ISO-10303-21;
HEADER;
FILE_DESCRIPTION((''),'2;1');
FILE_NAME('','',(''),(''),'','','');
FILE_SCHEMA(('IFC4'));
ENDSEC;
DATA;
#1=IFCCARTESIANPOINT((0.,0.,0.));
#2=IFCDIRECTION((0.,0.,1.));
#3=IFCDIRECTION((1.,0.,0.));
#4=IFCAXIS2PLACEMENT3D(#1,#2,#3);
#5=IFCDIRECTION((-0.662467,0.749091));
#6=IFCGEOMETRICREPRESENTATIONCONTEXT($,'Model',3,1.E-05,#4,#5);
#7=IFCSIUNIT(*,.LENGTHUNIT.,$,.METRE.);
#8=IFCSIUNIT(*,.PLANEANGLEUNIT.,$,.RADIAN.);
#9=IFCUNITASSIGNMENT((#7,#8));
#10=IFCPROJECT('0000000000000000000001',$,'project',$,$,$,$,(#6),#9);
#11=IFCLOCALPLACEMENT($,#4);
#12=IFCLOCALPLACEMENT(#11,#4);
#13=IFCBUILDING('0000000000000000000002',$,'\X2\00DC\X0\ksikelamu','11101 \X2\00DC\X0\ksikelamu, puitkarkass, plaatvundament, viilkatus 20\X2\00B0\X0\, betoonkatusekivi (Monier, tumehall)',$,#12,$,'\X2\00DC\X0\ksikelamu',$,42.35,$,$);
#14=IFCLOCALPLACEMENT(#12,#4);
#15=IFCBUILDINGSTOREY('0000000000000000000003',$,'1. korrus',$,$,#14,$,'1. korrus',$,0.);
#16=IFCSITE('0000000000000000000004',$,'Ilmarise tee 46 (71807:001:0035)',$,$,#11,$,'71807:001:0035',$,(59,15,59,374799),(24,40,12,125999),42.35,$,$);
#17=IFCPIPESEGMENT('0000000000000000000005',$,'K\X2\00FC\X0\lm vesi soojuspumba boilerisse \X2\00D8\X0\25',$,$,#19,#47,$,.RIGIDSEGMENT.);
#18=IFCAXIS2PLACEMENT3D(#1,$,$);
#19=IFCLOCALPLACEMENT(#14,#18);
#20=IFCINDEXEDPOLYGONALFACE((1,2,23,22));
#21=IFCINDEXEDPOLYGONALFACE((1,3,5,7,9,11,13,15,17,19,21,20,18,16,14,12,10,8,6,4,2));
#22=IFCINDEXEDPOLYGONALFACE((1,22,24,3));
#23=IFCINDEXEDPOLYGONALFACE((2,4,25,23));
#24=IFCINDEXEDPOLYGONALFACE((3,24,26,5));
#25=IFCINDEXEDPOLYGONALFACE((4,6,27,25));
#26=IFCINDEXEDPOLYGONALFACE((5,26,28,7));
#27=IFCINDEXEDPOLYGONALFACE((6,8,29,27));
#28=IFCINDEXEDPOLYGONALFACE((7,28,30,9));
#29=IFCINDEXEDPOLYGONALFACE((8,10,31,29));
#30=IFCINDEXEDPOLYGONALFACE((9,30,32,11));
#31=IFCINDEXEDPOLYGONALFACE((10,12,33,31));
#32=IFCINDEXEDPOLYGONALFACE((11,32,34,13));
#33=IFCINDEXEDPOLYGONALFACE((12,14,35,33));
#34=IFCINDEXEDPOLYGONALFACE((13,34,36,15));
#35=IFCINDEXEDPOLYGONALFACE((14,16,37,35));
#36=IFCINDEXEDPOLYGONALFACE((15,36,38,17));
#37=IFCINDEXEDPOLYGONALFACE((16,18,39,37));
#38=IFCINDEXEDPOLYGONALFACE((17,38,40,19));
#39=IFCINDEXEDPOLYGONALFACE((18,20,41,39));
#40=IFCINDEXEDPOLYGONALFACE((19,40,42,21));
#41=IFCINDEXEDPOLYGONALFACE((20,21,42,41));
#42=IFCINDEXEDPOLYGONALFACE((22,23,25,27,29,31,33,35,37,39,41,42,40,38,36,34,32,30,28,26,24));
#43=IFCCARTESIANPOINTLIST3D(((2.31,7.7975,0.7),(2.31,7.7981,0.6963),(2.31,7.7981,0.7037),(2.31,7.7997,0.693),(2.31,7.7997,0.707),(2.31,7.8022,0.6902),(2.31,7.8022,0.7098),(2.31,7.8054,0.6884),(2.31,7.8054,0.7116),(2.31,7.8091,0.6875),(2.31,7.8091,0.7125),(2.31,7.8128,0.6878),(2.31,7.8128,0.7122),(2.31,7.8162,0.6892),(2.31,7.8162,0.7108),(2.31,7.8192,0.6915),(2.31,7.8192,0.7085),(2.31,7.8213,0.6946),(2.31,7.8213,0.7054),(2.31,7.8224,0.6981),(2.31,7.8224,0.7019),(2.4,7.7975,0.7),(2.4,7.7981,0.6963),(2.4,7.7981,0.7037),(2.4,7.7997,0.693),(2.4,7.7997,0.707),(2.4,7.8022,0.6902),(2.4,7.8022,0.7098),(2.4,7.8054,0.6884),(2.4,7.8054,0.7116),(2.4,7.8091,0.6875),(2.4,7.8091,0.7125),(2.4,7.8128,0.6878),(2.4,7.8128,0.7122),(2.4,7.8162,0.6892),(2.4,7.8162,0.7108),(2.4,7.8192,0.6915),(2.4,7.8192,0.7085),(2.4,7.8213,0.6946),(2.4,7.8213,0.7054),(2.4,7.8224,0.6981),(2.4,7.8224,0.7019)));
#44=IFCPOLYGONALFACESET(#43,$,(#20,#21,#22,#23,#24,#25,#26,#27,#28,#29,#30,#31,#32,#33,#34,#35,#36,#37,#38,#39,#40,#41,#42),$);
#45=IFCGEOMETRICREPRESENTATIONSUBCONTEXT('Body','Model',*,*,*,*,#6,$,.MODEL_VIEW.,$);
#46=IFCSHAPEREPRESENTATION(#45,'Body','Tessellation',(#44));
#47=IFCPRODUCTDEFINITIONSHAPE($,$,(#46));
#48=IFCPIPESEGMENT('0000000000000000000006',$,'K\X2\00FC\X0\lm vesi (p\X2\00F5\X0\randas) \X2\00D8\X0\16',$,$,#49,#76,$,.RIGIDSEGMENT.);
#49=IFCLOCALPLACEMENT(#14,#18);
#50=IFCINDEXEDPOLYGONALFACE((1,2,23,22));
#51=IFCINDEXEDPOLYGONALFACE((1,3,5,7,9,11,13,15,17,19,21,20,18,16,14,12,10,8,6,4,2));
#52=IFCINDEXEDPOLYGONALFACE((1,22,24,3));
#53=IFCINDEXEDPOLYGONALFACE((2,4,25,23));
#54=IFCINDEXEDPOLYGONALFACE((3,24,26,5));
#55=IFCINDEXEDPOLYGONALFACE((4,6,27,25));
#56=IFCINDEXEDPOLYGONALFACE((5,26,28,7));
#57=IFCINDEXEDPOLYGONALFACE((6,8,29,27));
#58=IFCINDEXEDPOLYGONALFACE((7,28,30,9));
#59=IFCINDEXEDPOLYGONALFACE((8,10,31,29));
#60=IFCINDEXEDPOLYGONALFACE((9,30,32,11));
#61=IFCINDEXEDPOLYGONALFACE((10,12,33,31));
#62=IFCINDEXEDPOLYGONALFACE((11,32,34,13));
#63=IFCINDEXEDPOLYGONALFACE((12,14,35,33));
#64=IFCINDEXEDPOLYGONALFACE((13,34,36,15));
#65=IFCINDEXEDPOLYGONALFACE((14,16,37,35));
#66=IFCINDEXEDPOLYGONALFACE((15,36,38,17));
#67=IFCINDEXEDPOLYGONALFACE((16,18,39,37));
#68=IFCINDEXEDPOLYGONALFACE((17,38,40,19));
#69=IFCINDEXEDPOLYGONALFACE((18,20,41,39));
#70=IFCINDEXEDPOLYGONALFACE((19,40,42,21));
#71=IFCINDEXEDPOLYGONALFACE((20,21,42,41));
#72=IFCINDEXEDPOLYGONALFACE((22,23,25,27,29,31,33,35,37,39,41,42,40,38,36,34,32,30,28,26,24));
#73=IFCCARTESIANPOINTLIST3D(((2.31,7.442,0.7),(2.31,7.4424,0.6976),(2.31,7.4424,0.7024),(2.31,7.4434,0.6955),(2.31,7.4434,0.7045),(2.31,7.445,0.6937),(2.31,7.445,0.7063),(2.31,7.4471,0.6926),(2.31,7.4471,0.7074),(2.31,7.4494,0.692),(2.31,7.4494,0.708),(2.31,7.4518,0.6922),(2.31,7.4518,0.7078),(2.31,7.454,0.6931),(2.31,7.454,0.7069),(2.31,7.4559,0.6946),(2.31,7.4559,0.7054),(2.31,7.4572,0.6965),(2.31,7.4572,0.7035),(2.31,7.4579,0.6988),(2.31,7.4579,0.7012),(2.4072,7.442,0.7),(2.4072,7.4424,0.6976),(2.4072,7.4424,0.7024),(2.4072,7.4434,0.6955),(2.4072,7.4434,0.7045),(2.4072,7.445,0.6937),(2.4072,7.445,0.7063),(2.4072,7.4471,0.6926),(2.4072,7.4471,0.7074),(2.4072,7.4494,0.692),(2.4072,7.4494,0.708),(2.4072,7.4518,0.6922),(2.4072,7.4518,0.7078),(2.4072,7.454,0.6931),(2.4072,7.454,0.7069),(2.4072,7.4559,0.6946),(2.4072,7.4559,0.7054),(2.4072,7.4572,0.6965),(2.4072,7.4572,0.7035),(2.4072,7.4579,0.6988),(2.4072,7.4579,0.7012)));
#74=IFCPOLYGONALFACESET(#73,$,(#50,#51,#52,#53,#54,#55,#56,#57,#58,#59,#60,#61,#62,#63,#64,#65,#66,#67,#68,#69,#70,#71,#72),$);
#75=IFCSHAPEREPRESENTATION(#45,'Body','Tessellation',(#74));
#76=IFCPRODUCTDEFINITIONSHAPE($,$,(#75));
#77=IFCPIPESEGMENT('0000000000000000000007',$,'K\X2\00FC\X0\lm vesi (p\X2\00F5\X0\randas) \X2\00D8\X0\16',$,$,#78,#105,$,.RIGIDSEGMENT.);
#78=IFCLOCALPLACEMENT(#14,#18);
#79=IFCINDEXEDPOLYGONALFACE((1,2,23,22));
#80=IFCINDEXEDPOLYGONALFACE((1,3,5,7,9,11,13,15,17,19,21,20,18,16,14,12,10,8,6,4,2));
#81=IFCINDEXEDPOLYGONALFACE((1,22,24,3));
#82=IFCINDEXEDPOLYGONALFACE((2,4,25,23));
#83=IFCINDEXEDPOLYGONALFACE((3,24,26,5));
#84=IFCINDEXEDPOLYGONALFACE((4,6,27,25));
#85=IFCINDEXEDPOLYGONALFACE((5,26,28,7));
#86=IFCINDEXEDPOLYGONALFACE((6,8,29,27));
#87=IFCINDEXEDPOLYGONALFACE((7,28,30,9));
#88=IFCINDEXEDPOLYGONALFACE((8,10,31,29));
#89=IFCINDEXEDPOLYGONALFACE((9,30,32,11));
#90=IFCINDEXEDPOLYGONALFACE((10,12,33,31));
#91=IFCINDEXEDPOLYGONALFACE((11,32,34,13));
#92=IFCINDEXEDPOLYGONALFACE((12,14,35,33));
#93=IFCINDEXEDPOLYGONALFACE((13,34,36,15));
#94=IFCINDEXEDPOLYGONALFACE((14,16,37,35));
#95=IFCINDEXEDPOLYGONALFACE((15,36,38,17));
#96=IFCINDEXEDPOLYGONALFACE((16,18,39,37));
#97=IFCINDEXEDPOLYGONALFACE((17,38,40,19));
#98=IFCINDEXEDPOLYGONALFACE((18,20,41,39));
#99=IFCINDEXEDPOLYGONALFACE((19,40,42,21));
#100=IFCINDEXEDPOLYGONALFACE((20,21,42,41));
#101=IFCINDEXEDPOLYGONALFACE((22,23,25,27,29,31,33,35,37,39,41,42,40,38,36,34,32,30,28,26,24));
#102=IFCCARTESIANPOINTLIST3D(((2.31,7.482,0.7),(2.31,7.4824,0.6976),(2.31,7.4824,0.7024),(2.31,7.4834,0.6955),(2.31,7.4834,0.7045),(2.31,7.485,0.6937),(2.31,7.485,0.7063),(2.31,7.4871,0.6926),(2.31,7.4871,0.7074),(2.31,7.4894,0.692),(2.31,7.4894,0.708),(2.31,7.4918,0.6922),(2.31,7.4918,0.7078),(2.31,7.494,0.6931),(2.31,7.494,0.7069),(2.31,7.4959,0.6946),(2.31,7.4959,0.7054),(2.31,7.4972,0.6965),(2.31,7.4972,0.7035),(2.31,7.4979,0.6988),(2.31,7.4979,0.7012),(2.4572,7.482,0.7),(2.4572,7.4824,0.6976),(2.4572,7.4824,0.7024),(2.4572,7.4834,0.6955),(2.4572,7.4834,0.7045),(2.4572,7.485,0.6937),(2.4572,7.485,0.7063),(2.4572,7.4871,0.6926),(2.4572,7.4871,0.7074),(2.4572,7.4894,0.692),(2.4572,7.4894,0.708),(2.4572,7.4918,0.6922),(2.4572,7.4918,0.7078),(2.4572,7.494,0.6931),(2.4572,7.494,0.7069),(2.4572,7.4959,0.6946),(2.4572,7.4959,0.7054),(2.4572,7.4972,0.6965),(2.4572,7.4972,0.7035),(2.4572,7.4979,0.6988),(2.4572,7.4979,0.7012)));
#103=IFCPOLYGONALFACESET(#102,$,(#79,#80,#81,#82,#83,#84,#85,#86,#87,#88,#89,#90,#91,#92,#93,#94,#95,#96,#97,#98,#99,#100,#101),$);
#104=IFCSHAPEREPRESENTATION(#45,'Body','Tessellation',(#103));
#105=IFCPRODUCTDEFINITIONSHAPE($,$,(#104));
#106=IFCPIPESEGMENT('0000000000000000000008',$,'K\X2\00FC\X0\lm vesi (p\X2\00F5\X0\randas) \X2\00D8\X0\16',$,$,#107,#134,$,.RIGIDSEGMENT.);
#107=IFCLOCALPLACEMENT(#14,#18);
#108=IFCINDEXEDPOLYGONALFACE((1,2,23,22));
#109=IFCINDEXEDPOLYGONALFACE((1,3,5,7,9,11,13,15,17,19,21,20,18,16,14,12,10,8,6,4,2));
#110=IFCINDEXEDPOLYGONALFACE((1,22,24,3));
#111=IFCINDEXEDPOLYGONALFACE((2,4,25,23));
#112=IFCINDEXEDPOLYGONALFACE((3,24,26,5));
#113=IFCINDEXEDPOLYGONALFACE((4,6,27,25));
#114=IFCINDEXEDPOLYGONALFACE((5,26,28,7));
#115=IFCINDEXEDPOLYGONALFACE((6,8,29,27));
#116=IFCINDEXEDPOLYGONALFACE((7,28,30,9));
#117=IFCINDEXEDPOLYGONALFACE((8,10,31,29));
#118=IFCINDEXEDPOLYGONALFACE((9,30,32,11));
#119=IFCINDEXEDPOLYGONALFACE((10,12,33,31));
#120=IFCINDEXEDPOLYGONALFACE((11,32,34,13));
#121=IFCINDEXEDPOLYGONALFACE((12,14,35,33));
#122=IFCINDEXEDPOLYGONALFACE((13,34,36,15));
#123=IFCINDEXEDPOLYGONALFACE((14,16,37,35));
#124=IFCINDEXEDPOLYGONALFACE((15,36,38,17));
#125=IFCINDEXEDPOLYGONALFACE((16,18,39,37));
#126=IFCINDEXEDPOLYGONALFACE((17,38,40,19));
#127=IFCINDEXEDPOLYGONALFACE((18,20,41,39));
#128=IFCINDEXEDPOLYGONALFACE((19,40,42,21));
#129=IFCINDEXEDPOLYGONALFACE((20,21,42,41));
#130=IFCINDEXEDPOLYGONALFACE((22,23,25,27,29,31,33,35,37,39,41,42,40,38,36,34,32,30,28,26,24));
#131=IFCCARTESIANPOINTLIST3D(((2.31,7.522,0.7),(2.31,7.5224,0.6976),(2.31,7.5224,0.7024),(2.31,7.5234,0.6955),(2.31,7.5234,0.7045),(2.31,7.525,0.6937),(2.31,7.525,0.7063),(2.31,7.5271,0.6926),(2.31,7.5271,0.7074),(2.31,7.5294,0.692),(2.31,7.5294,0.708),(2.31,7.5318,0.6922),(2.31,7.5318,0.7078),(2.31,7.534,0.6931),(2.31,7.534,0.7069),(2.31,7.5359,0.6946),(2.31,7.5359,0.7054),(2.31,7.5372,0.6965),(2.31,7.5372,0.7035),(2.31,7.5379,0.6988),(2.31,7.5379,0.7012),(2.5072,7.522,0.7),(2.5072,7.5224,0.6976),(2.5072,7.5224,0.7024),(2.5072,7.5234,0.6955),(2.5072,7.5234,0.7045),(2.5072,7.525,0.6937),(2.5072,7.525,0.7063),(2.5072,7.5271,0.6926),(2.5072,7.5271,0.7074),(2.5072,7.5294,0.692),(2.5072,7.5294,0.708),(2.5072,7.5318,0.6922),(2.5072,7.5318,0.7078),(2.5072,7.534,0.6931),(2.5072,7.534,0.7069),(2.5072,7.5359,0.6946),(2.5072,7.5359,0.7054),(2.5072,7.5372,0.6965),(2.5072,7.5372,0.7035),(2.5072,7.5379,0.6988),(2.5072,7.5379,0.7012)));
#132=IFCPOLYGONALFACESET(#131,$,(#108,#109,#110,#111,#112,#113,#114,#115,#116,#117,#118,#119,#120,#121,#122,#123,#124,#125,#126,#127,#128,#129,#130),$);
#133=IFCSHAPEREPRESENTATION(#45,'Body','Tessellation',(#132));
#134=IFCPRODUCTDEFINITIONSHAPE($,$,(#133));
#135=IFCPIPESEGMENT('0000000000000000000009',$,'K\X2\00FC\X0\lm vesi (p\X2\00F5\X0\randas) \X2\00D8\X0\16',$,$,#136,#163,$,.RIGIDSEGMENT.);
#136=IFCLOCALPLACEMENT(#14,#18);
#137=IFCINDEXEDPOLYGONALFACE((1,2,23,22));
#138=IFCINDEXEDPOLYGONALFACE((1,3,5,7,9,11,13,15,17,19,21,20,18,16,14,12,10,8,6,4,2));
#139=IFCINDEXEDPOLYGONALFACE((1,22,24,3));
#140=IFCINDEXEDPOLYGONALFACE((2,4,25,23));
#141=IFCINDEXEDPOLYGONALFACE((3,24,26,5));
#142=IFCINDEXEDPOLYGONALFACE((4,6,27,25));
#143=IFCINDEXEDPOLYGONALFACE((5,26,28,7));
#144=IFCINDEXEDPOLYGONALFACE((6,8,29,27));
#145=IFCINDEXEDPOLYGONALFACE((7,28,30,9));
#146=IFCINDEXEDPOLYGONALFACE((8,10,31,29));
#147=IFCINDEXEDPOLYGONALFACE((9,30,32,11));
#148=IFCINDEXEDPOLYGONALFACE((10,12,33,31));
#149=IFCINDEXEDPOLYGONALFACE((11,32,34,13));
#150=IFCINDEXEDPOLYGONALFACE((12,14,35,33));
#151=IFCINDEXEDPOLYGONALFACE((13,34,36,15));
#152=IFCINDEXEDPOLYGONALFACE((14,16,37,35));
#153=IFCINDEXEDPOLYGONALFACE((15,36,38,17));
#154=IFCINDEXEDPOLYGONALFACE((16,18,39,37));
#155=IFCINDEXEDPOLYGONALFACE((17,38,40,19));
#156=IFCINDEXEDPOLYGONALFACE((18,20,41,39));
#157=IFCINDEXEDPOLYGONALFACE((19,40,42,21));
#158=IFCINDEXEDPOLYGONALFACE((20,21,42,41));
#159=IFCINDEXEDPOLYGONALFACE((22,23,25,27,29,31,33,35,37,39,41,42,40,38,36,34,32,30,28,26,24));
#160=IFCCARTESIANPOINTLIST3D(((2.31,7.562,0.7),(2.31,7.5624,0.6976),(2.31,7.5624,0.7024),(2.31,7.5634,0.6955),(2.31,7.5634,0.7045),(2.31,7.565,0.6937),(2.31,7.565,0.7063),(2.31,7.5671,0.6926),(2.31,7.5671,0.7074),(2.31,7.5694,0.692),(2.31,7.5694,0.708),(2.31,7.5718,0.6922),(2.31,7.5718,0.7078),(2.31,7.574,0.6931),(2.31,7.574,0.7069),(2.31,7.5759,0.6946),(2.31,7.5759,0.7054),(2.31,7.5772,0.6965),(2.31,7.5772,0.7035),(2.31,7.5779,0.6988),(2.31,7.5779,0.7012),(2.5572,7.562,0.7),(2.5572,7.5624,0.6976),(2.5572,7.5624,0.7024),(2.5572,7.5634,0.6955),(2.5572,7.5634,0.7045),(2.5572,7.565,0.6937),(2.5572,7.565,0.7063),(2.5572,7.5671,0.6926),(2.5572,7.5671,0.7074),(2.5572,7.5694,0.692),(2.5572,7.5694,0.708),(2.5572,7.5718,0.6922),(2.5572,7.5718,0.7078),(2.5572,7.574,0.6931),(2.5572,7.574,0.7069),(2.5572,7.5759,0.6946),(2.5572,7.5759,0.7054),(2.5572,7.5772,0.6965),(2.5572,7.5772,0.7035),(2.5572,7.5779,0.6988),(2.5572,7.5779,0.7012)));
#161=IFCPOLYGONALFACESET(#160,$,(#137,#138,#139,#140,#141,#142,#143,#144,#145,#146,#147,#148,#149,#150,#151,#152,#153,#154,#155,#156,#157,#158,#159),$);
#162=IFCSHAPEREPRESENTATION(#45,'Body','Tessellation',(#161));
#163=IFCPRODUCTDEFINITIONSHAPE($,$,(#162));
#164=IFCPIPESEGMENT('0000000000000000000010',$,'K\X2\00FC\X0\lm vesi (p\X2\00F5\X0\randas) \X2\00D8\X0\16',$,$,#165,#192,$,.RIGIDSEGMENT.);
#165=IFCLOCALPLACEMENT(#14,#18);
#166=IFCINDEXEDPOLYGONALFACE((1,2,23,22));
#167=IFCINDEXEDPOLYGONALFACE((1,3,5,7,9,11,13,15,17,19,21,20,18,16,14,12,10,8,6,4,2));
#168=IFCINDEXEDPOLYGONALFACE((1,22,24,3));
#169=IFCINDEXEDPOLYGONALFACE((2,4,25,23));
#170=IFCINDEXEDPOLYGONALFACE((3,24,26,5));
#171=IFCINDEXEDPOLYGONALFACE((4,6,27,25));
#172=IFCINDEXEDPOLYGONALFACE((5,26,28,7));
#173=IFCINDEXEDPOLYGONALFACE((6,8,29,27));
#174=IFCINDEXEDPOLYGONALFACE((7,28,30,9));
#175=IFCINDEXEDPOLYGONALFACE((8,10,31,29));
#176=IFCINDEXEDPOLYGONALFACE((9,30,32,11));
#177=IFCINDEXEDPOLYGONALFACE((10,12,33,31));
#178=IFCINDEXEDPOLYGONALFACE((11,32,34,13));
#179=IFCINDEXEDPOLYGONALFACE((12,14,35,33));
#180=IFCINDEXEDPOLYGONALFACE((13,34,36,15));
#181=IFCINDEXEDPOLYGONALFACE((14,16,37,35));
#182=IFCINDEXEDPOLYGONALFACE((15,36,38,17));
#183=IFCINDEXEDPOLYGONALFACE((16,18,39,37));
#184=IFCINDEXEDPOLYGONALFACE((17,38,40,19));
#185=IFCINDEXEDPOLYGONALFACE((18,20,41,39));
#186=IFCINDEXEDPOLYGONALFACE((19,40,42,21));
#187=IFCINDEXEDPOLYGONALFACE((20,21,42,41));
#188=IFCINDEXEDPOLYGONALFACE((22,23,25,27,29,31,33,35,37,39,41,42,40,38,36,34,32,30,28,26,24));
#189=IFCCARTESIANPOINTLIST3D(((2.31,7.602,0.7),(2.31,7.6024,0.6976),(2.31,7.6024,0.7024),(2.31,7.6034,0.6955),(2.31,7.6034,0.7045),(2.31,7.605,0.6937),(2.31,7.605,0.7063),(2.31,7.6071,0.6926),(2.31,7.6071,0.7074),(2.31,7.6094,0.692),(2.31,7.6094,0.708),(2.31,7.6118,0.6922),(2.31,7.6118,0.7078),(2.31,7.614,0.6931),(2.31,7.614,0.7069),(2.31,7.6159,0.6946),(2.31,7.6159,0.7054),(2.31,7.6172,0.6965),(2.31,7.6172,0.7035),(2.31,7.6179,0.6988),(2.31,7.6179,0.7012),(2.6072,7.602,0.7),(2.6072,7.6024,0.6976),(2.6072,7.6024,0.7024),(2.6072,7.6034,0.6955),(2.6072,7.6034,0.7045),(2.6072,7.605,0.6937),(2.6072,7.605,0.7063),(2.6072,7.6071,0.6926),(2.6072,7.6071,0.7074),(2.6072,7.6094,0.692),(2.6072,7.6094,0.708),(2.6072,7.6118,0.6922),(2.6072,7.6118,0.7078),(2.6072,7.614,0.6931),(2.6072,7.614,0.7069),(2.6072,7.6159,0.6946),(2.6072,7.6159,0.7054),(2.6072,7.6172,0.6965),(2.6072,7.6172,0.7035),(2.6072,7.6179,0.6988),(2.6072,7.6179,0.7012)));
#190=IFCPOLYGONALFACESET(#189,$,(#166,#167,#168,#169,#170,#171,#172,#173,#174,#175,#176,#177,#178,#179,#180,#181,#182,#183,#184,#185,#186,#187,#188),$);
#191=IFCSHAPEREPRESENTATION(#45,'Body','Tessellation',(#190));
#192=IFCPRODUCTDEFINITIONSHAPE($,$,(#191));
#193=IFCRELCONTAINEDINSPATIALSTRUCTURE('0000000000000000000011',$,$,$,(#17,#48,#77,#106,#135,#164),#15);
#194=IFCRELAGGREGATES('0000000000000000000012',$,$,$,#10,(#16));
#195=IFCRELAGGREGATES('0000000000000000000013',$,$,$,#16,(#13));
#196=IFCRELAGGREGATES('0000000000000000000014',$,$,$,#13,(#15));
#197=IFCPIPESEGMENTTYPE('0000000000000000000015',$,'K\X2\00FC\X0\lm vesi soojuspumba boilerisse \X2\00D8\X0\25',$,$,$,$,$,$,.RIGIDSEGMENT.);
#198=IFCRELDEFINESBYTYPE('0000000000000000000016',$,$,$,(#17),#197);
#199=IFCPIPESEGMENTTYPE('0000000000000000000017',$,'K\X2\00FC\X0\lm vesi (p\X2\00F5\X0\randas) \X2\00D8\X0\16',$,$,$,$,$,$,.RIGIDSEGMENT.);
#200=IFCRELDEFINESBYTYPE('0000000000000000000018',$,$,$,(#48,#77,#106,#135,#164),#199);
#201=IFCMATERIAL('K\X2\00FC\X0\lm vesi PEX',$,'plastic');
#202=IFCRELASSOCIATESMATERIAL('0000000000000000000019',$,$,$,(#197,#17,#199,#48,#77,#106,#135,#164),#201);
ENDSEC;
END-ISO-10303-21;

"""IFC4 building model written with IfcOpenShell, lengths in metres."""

from ifc_helpers import new_model, si_unit, direction, frame, origin_with_axes, place, context, subcontext, project, spatial, circle, extrude, material, type_object, element, save


model = new_model("IFC4")

# Units and contexts
model_context = context("Model", 3, precision=1e-05, world=origin_with_axes(), true_north=direction((-0.662467, 0.749091)))
body_context = subcontext(model_context, "Body", "Model", "MODEL_VIEW")
ifc_project = project(units=[si_unit("LENGTHUNIT", "METRE"), si_unit("PLANEANGLEUNIT", "RADIAN")], contexts=[model_context])

# Site, building, storey
site_placement = place(None, origin_with_axes())
site = spatial("IfcSite", under=ifc_project, at=site_placement, Name="Ilmarise tee 46 (71807:001:0035)", LongName="71807:001:0035", RefLatitude=(59, 15, 59, 374799), RefLongitude=(24, 40, 12, 125999), RefElevation=42.35)
building_placement = place(site_placement, origin_with_axes())
building = spatial("IfcBuilding", under=site, at=building_placement, Name="Üksikelamu", Description="11101 Üksikelamu, puitkarkass, plaatvundament, viilkatus 20°, betoonkatusekivi (Monier, tumehall)", LongName="Üksikelamu", ElevationOfRefHeight=42.35)
storey_placement = place(building_placement, origin_with_axes())
storey = spatial("IfcBuildingStorey", under=building, at=storey_placement, Name="1. korrus", LongName="1. korrus", Elevation=0.0)

# Pipe segments
ifc_material_1 = material(Name="Külm vesi PEX", Category="plastic")
pipe_segment_type_1 = type_object("IfcPipeSegmentType", Name="Külm vesi soojuspumba boilerisse Ø25", PredefinedType="RIGIDSEGMENT", material=ifc_material_1)
pipe_segment_1_placement = place(storey_placement, frame((2.31, 7.81, 0.7), z_axis=(1.0, 0.0, 0.0), x_axis=(0.0, -1.0, 0.0)))
element("IfcPipeSegment", 1, at=pipe_segment_1_placement, inside=storey, type_object=pipe_segment_type_1, material=ifc_material_1, Name="Külm vesi soojuspumba boilerisse Ø25", PredefinedType="RIGIDSEGMENT", context=body_context, shape_type="SweptSolid", body=[
    extrude(circle(Radius=0.0125), origin_with_axes(), (0.0, 0.0, 1.0), 0.09),
])
pipe_segment_type_2 = type_object("IfcPipeSegmentType", Name="Külm vesi (põrandas) Ø16", PredefinedType="RIGIDSEGMENT", material=ifc_material_1)
pipe_segment_2_placement = place(storey_placement, frame((2.31, 7.45, 0.7), z_axis=(1.0, 0.0, 0.0), x_axis=(0.0, -1.0, 0.0)))
element("IfcPipeSegment", 2, at=pipe_segment_2_placement, inside=storey, type_object=pipe_segment_type_2, material=ifc_material_1, Name="Külm vesi (põrandas) Ø16", PredefinedType="RIGIDSEGMENT", context=body_context, shape_type="SweptSolid", body=[
    extrude(circle(Radius=0.008), origin_with_axes(), (0.0, 0.0, 1.0), 0.0972),
])
pipe_segment_3_placement = place(storey_placement, frame((2.31, 7.49, 0.7), z_axis=(1.0, 0.0, 0.0), x_axis=(0.0, -1.0, 0.0)))
element("IfcPipeSegment", 3, at=pipe_segment_3_placement, inside=storey, type_object=pipe_segment_type_2, material=ifc_material_1, Name="Külm vesi (põrandas) Ø16", PredefinedType="RIGIDSEGMENT", context=body_context, shape_type="SweptSolid", body=[
    extrude(circle(Radius=0.008), origin_with_axes(), (0.0, 0.0, 1.0), 0.1472),
])
pipe_segment_4_placement = place(storey_placement, frame((2.31, 7.53, 0.7), z_axis=(1.0, 0.0, 0.0), x_axis=(0.0, -1.0, 0.0)))
element("IfcPipeSegment", 4, at=pipe_segment_4_placement, inside=storey, type_object=pipe_segment_type_2, material=ifc_material_1, Name="Külm vesi (põrandas) Ø16", PredefinedType="RIGIDSEGMENT", context=body_context, shape_type="SweptSolid", body=[
    extrude(circle(Radius=0.008), origin_with_axes(), (0.0, 0.0, 1.0), 0.1972),
])
pipe_segment_5_placement = place(storey_placement, frame((2.31, 7.57, 0.7), z_axis=(1.0, 0.0, 0.0), x_axis=(0.0, -1.0, 0.0)))
element("IfcPipeSegment", 5, at=pipe_segment_5_placement, inside=storey, type_object=pipe_segment_type_2, material=ifc_material_1, Name="Külm vesi (põrandas) Ø16", PredefinedType="RIGIDSEGMENT", context=body_context, shape_type="SweptSolid", body=[
    extrude(circle(Radius=0.008), origin_with_axes(), (0.0, 0.0, 1.0), 0.2472),
])
pipe_segment_6_placement = place(storey_placement, frame((2.31, 7.61, 0.7), z_axis=(1.0, 0.0, 0.0), x_axis=(0.0, -1.0, 0.0)))
element("IfcPipeSegment", 6, at=pipe_segment_6_placement, inside=storey, type_object=pipe_segment_type_2, material=ifc_material_1, Name="Külm vesi (põrandas) Ø16", PredefinedType="RIGIDSEGMENT", context=body_context, shape_type="SweptSolid", body=[
    extrude(circle(Radius=0.008), origin_with_axes(), (0.0, 0.0, 1.0), 0.2972),
])

save(model, "model.ifc")
